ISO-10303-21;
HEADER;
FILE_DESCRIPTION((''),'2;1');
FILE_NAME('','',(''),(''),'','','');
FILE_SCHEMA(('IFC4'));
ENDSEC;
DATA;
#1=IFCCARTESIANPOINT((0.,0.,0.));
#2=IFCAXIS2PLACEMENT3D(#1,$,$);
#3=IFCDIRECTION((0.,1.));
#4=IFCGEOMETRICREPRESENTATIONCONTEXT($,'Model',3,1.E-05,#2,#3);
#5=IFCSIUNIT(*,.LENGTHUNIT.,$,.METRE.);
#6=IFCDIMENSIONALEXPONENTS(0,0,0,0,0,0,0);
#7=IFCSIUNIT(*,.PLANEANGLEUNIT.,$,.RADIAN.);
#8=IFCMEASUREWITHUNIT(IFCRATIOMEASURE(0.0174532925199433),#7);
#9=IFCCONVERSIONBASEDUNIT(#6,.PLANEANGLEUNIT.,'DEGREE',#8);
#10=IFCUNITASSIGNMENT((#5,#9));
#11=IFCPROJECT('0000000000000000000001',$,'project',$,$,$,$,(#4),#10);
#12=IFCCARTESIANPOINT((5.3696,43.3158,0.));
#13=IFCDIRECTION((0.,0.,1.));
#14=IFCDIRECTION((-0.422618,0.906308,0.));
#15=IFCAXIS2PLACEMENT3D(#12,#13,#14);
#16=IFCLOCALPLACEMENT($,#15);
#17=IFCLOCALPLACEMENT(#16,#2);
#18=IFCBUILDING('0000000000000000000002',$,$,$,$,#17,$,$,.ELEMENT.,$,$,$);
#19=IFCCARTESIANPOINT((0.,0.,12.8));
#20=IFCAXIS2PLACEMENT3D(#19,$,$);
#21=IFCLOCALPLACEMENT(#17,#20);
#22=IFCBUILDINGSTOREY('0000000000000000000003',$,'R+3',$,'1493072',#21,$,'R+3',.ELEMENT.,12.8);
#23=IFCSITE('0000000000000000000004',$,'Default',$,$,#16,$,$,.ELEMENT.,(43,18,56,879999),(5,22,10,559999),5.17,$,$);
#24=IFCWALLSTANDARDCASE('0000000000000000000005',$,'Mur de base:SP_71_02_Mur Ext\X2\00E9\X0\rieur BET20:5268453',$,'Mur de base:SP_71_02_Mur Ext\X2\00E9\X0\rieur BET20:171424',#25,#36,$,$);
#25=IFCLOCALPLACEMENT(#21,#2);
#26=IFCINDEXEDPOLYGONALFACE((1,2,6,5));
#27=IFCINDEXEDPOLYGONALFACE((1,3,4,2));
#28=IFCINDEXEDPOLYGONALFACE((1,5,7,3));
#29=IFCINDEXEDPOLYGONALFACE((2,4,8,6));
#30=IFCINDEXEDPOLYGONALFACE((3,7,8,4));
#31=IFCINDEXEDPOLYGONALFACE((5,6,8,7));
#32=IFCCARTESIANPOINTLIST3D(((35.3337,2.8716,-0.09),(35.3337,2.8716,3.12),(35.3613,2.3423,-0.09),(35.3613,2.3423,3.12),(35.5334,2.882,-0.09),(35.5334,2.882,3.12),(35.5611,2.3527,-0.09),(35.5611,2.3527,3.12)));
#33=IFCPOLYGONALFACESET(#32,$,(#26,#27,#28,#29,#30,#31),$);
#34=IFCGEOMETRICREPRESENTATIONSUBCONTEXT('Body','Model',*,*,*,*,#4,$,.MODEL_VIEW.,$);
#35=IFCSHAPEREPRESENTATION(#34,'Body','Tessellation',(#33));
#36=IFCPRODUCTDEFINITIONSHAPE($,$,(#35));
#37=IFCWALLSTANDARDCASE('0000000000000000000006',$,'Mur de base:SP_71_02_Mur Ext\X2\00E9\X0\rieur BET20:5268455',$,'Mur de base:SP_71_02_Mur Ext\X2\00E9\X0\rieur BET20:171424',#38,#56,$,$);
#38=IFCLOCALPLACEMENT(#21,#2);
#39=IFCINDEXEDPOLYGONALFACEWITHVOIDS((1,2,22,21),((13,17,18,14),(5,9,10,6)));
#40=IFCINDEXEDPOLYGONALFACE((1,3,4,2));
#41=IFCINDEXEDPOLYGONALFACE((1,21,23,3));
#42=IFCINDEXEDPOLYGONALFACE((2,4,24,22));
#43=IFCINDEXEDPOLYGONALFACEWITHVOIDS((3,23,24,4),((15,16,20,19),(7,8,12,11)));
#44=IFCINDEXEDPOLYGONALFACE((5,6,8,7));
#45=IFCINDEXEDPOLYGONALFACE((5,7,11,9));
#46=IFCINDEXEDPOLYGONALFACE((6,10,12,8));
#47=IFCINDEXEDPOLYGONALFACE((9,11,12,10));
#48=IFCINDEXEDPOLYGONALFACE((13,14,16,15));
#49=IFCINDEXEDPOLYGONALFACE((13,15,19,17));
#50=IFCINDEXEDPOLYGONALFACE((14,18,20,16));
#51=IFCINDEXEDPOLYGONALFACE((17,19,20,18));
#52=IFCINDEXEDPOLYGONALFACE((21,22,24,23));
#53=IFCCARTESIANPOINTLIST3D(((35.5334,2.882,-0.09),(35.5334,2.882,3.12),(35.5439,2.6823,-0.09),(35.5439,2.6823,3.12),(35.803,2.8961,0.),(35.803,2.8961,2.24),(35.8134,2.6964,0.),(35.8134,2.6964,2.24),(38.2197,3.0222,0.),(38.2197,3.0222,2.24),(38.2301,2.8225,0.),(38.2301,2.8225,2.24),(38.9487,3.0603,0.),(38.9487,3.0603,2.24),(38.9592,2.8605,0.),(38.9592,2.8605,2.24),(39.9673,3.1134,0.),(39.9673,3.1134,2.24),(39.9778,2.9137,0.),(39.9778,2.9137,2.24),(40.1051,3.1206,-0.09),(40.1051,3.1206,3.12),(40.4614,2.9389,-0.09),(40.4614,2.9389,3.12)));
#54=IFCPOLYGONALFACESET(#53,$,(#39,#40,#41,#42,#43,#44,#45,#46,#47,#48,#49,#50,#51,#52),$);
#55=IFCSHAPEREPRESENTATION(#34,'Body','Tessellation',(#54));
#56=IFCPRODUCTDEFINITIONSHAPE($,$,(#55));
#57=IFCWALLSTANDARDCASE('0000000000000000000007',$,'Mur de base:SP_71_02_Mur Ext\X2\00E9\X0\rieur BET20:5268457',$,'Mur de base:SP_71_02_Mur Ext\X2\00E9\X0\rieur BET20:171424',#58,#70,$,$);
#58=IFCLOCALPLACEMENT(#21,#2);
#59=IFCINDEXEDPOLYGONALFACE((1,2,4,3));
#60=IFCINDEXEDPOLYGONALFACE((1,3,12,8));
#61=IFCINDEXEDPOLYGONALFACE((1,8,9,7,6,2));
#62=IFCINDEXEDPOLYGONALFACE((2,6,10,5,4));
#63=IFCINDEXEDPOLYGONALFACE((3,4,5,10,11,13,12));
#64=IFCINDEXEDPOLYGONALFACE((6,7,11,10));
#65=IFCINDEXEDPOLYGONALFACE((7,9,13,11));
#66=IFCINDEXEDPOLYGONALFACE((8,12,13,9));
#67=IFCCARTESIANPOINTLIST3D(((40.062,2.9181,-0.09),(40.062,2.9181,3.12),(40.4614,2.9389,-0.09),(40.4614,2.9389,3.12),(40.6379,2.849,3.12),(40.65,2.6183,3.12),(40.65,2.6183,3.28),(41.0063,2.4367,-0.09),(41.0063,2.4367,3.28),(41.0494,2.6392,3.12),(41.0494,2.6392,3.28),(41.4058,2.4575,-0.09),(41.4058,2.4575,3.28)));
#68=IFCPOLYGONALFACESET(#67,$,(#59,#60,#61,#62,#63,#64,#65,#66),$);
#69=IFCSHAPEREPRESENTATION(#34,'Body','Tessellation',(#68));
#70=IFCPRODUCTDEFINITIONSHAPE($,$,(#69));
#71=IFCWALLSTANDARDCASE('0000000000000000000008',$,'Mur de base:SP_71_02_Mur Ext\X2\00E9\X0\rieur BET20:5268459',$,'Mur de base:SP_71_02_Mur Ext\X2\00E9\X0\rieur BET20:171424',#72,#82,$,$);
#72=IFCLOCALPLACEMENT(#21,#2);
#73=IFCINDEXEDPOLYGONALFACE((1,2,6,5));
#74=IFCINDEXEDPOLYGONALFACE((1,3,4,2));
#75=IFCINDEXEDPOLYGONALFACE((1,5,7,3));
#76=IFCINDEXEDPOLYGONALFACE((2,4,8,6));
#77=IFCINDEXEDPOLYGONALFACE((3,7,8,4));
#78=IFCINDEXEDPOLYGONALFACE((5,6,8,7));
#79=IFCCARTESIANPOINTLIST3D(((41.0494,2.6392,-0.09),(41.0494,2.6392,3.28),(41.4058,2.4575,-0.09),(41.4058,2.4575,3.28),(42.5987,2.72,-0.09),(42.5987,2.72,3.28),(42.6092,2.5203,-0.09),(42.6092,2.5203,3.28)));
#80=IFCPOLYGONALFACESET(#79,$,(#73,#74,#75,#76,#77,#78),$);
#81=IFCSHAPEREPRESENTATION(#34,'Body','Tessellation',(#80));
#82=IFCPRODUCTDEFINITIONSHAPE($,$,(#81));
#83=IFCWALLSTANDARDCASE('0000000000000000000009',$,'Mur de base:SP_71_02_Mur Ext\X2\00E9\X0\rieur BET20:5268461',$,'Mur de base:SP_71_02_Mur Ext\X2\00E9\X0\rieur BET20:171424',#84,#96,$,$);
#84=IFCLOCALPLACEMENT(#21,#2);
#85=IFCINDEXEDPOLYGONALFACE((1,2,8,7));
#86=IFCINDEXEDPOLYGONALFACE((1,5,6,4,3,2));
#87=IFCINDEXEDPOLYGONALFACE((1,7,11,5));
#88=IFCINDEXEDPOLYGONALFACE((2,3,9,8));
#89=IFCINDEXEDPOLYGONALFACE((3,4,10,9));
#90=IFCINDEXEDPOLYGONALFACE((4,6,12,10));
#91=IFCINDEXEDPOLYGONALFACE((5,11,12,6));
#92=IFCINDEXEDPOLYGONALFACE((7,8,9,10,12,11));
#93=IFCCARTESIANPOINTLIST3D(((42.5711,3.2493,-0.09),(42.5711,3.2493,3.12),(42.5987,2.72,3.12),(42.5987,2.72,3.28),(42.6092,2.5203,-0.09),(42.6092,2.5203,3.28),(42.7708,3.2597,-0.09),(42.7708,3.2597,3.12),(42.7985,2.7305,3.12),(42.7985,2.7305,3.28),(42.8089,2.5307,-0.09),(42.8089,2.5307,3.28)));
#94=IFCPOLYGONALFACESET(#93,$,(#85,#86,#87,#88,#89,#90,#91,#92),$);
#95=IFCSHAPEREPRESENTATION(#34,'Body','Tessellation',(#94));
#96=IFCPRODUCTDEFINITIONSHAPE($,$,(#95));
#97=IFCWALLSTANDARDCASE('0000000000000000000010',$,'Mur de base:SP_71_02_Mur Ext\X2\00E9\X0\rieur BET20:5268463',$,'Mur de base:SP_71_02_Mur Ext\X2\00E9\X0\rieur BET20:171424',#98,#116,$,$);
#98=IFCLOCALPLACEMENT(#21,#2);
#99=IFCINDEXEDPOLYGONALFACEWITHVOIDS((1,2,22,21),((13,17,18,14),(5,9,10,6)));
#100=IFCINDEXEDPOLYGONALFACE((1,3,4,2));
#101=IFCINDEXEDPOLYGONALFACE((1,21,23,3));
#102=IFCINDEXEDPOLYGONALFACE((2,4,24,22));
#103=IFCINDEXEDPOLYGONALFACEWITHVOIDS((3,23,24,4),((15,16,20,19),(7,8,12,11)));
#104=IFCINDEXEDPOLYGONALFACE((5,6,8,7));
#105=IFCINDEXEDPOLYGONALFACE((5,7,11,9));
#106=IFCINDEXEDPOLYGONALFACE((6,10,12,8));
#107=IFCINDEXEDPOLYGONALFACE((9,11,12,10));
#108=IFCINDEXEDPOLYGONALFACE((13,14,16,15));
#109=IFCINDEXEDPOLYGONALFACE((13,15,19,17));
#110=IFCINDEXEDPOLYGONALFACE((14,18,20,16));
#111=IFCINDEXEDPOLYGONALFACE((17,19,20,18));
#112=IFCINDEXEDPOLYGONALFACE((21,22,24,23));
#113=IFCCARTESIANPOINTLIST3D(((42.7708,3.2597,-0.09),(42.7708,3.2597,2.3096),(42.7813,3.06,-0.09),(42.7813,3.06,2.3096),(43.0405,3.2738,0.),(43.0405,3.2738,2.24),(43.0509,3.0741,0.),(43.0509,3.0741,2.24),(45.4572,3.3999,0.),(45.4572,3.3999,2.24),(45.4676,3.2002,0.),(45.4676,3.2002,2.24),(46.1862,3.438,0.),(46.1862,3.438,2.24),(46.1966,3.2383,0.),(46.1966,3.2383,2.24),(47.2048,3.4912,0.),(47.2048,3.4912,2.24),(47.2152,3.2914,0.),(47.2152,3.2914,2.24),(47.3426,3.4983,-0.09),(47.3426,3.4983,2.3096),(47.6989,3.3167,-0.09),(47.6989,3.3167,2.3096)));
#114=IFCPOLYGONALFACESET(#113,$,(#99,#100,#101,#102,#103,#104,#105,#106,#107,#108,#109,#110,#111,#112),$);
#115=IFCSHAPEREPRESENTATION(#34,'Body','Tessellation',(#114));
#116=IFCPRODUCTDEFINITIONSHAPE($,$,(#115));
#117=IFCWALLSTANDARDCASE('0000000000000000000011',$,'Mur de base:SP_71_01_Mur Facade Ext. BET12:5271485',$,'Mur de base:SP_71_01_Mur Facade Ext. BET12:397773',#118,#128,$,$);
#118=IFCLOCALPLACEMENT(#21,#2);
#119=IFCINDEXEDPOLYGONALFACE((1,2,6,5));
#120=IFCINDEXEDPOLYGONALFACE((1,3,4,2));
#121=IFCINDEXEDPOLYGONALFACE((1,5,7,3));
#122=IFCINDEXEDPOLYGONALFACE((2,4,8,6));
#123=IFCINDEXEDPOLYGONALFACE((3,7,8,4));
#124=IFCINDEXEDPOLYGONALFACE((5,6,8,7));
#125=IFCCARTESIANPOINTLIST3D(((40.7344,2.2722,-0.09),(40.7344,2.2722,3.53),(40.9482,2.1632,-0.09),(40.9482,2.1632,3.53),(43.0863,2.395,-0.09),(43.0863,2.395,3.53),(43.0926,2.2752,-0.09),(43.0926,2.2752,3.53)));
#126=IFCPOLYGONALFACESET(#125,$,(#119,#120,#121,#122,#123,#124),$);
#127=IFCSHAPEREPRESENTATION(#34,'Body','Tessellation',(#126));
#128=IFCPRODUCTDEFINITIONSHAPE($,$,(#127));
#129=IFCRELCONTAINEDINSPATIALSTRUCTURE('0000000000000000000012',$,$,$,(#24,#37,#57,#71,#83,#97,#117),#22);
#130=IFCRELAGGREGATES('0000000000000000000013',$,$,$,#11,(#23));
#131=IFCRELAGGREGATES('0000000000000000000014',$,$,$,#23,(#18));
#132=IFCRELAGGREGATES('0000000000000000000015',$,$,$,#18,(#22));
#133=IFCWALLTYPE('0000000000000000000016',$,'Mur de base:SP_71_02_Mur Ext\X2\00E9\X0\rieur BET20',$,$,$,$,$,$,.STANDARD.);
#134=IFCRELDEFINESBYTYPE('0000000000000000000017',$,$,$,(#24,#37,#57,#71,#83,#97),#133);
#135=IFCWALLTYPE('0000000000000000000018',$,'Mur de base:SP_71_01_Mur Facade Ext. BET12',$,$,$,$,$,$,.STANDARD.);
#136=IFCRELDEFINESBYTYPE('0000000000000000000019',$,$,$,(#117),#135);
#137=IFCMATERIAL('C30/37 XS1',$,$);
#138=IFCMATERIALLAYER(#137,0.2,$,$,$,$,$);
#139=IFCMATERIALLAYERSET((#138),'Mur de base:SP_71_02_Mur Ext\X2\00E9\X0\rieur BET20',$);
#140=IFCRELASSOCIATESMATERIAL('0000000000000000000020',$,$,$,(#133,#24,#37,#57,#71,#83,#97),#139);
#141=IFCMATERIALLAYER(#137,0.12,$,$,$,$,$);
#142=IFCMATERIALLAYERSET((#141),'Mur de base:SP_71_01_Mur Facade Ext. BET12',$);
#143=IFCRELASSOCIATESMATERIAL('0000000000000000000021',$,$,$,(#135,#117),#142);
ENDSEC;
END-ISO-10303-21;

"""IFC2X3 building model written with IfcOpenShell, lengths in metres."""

from ifc_helpers import new_model, entity, si_unit, converted_unit, direction, frame, frame_2d, origin, place, context, subcontext, project, spatial, polyline, rectangle, outline, extrude, clip, halfspace, bounded_halfspace, material, layer, layer_set, layer_usage, type_object, element, save


model = new_model("IFC2X3")

# Units and contexts
model_context = context("Model", 3, precision=1e-05, world=origin(), true_north=direction((0.0, 1.0)))
body_context = subcontext(model_context, "Body", "Model", "MODEL_VIEW")
ifc_project = project(units=[si_unit("LENGTHUNIT", "METRE"), converted_unit("PLANEANGLEUNIT", "DEGREE", entity("IfcRatioMeasure", 0.0174532925199433), si_unit("PLANEANGLEUNIT", "RADIAN"), dimensions=[0, 0, 0, 0, 0, 0, 0])], contexts=[model_context])

# Site, building, storey
site_placement = place(None, frame((5.3696, 43.3158, 0.0), z_axis=(0.0, 0.0, 1.0), x_axis=(-0.422618, 0.906308, 0.0)))
site = spatial("IfcSite", under=ifc_project, at=site_placement, Name="Default", CompositionType="ELEMENT", RefLatitude=(43, 18, 56, 879999), RefLongitude=(5, 22, 10, 559999), RefElevation=5.17)
building_placement = place(site_placement, origin())
building = spatial("IfcBuilding", under=site, at=building_placement, CompositionType="ELEMENT")
storey_placement = place(building_placement, frame((0.0, 0.0, 12.8)))
storey = spatial("IfcBuildingStorey", under=building, at=storey_placement, Name="R+3", ObjectType="1493072", LongName="R+3", CompositionType="ELEMENT", Elevation=12.8)

# Shared definitions
ifc_material = material(Name="C30/37 XS1")

# Wall
ifc_layer_1 = layer(ifc_material, 0.2)
ifc_layer_set_1 = layer_set([ifc_layer_1], Name="Mur de base:SP_71_02_Mur Extérieur BET20")
ifc_layer_usage_1 = layer_usage(ifc_layer_set_1, "AXIS2", "NEGATIVE", 0.1)
wall_type_1 = type_object("IfcWallType", Name="Mur de base:SP_71_02_Mur Extérieur BET20", PredefinedType="STANDARD", material=ifc_layer_set_1)
wall_1_placement = place(storey_placement, frame((35.4336, 2.8768, -0.09), z_axis=(0.0, 0.0, 1.0), x_axis=(0.05212, -0.998641, 0.0)))
element("IfcWallStandardCase", 1, at=wall_1_placement, inside=storey, type_object=wall_type_1, material=ifc_layer_usage_1, Name="Mur de base:SP_71_02_Mur Extérieur BET20:5268453", ObjectType="Mur de base:SP_71_02_Mur Extérieur BET20:171424", context=body_context, shape_type="Clipping", body=[
    clip(extrude(rectangle(XDim=0.53, YDim=0.2, at=frame_2d((0.265, 0.0), x_axis=(-1.0, 0.0))), origin(), (0.0, 0.0, 1.0), 3.21), bounded_halfspace(frame((0.0, -0.1, 3.21), z_axis=(0.0, 0.0, -1.0), x_axis=(0.998641, -0.05212, 0.0)), True, frame((0.0, -0.1, 3.21), z_axis=(0.0, 0.0, -1.0), x_axis=(0.998641, -0.05212, 0.0)), polyline([(0.0, 0.0), (-0.0104, -0.1997), (0.1893, -0.2102), (0.5189, -0.2274), (0.5293, -0.0276), (0.0, 0.0)]))),
])

# Wall, openings
ifc_layer_usage_2 = layer_usage(ifc_layer_set_1, "AXIS2", "NEGATIVE", 0.1)
wall_2_placement = place(storey_placement, frame((35.5387, 2.7821, -0.09), z_axis=(0.0, 0.0, 1.0), x_axis=(0.998641, 0.05212, 0.0)))
wall_2 = element("IfcWallStandardCase", 2, at=wall_2_placement, inside=storey, type_object=wall_type_1, material=ifc_layer_usage_2, Name="Mur de base:SP_71_02_Mur Extérieur BET20:5268455", ObjectType="Mur de base:SP_71_02_Mur Extérieur BET20:171424", context=body_context, shape_type="Clipping", body=[
    clip(extrude(outline(polyline([(4.9243, -0.1), (4.5778, 0.1), (0.0, 0.1), (0.0, -0.1), (4.5243, -0.1), (4.9243, -0.1)])), origin(), (0.0, 0.0, 1.0), 3.21), bounded_halfspace(frame((0.0, -0.1, 3.21), z_axis=(0.0, 0.0, -1.0), x_axis=(-0.05212, -0.998641, 0.0)), True, frame((0.0, -0.1, 3.21), z_axis=(0.0, 0.0, -1.0), x_axis=(-0.05212, -0.998641, 0.0)), polyline([(0.0, 0.0), (-0.1997, 0.0104), (-0.4383, -4.5612), (-0.2567, -4.9176), (-0.2358, -4.5181), (0.0, 0.0)]))),
])
opening_1_placement = place(wall_2_placement, origin())
element("IfcOpeningElement", 3, at=opening_1_placement, cuts=wall_2, ObjectType="Opening", context=body_context, shape_type="SweptSolid", body=[
    extrude(rectangle(XDim=2.24, YDim=2.42, at=frame_2d((0.0, 0.0), x_axis=(1.0, 0.0))), frame((1.4799, -1.424, 1.21), z_axis=(0.0, 1.0, 0.0), x_axis=(0.0, 0.0, -1.0)), (0.0, 0.0, 1.0), 3.048),
])
opening_2_placement = place(wall_2_placement, origin())
element("IfcOpeningElement", 4, at=opening_2_placement, cuts=wall_2, ObjectType="Opening", context=body_context, shape_type="SweptSolid", body=[
    extrude(rectangle(XDim=2.24, YDim=1.02, at=frame_2d((0.0, 0.0), x_axis=(1.0, 0.0))), frame((3.9299, -1.424, 1.21), z_axis=(0.0, 1.0, 0.0), x_axis=(0.0, 0.0, -1.0)), (0.0, 0.0, 1.0), 3.048),
])

# Walls
ifc_layer_usage_3 = layer_usage(ifc_layer_set_1, "AXIS2", "NEGATIVE", 0.1)
wall_3_placement = place(storey_placement, frame((40.1074, 3.0072, -0.09), z_axis=(0.0, 0.0, 1.0), x_axis=(0.890908, -0.454183, 0.0)))
element("IfcWallStandardCase", 5, at=wall_3_placement, inside=storey, type_object=wall_type_1, material=ifc_layer_usage_3, Name="Mur de base:SP_71_02_Mur Extérieur BET20:5268457", ObjectType="Mur de base:SP_71_02_Mur Extérieur BET20:171424", context=body_context, shape_type="Clipping", body=[
    clip(clip(extrude(outline(polyline([(1.06, -0.1), (1.4064, 0.1), (1.0064, 0.1), (0.3464, 0.1), (0.0, -0.1), (1.06, -0.1)])), origin(), (0.0, 0.0, 1.0), 3.37), bounded_halfspace(frame((0.66, -0.1, 3.21), z_axis=(0.0, 0.0, -1.0), x_axis=(0.454183, -0.890908, 0.0)), True, frame((0.66, -0.1, 3.21), z_axis=(0.0, 0.0, -1.0), x_axis=(0.454183, -0.890908, 0.0)), polyline([(0.0, 0.0), (-0.2998, 0.588), (-0.3206, 0.1885), (-0.0208, -0.3995), (0.0, 0.0)]))), bounded_halfspace(frame((1.0064, 0.1, 3.21), z_axis=(0.5, -0.866025, 0.0), x_axis=(0.0, 0.0, 1.0)), True, frame((1.0064, 0.1, 3.21), z_axis=(0.5, -0.866025, 0.0), x_axis=(0.0, 0.0, 1.0)), polyline([(0.0, 0.0), (0.16, 0.0), (0.16, 0.4), (0.0, 0.4), (0.0, 0.0)]))),
])
ifc_layer_usage_4 = layer_usage(ifc_layer_set_1, "AXIS2", "NEGATIVE", 0.1)
wall_4_placement = place(storey_placement, frame((41.0546, 2.5393, -0.09), z_axis=(0.0, 0.0, 1.0), x_axis=(0.998641, 0.05212, 0.0)))
element("IfcWallStandardCase", 6, at=wall_4_placement, inside=storey, type_object=wall_type_1, material=ifc_layer_usage_4, Name="Mur de base:SP_71_02_Mur Extérieur BET20:5268459", ObjectType="Mur de base:SP_71_02_Mur Extérieur BET20:171424", context=body_context, shape_type="SweptSolid", body=[
    extrude(outline(polyline([(1.5514, -0.1), (1.5514, 0.1), (0.0, 0.1), (0.3464, -0.1), (1.5514, -0.1)])), origin(), (0.0, 0.0, 1.0), 3.37),
])
ifc_layer_usage_5 = layer_usage(ifc_layer_set_1, "AXIS2", "NEGATIVE", 0.1)
wall_5_placement = place(storey_placement, frame((42.671, 3.2545, -0.09), z_axis=(0.0, 0.0, 1.0), x_axis=(0.05212, -0.998641, 0.0)))
element("IfcWallStandardCase", 7, at=wall_5_placement, inside=storey, type_object=wall_type_1, material=ifc_layer_usage_5, Name="Mur de base:SP_71_02_Mur Extérieur BET20:5268461", ObjectType="Mur de base:SP_71_02_Mur Extérieur BET20:171424", context=body_context, shape_type="Clipping", body=[
    clip(clip(extrude(rectangle(XDim=0.73, YDim=0.2, at=frame_2d((0.365, 0.0), x_axis=(-1.0, 0.0))), origin(), (0.0, 0.0, 1.0), 3.37), bounded_halfspace(frame((0.53, -0.1, 3.21), z_axis=(0.0, 0.0, -1.0), x_axis=(0.998641, -0.05212, 0.0)), True, frame((0.53, -0.1, 3.21), z_axis=(0.0, 0.0, -1.0), x_axis=(0.998641, -0.05212, 0.0)), polyline([(0.0, 0.0), (-0.5293, 0.0276), (-0.5397, -0.1721), (-0.0104, -0.1997), (0.0, 0.0)]))), bounded_halfspace(frame((0.53, 0.1, 3.21), z_axis=(1.0, 0.0, 0.0), x_axis=(0.0, 0.0, 1.0)), True, frame((0.53, 0.1, 3.21), z_axis=(1.0, 0.0, 0.0), x_axis=(0.0, 0.0, 1.0)), polyline([(0.0, 0.0), (0.16, 0.0), (0.16, 0.2), (0.0, 0.2), (0.0, 0.0)]))),
])

# Wall, openings
ifc_layer_usage_6 = layer_usage(ifc_layer_set_1, "AXIS2", "NEGATIVE", 0.1)
wall_6_placement = place(storey_placement, frame((42.7761, 3.1599, -0.09), z_axis=(0.0, 0.0, 1.0), x_axis=(0.998641, 0.05212, 0.0)))
wall_6 = element("IfcWallStandardCase", 8, at=wall_6_placement, inside=storey, type_object=wall_type_1, material=ifc_layer_usage_6, Name="Mur de base:SP_71_02_Mur Extérieur BET20:5268463", ObjectType="Mur de base:SP_71_02_Mur Extérieur BET20:171424", context=body_context, shape_type="Clipping", body=[
    clip(extrude(outline(polyline([(4.9244, -0.1), (4.5779, 0.1), (0.0, 0.1), (0.0, -0.1), (4.5244, -0.1), (4.9244, -0.1)])), origin(), (0.0, 0.0, 1.0), 2.3996), bounded_halfspace(frame((0.0, -0.1, 2.3996)), False, frame((0.0, -0.1, 2.3996)), polyline([(0.0, 0.0), (4.5244, 0.0), (4.9244, 0.0), (4.5779, 0.2), (0.0, 0.2), (0.0, 0.0)]))),
])
opening_3_placement = place(wall_6_placement, origin())
element("IfcOpeningElement", 9, at=opening_3_placement, cuts=wall_6, ObjectType="Opening", context=body_context, shape_type="SweptSolid", body=[
    extrude(rectangle(XDim=2.24, YDim=1.02, at=frame_2d((0.0, 0.0), x_axis=(1.0, 0.0))), frame((3.93, -1.424, 1.21), z_axis=(0.0, 1.0, 0.0), x_axis=(0.0, 0.0, -1.0)), (0.0, 0.0, 1.0), 3.048),
])
opening_4_placement = place(wall_6_placement, origin())
element("IfcOpeningElement", 10, at=opening_4_placement, cuts=wall_6, ObjectType="Opening", context=body_context, shape_type="SweptSolid", body=[
    extrude(rectangle(XDim=2.24, YDim=2.42, at=frame_2d((0.0, 0.0), x_axis=(1.0, 0.0))), frame((1.48, -1.424, 1.21), z_axis=(0.0, 1.0, 0.0), x_axis=(0.0, 0.0, -1.0)), (0.0, 0.0, 1.0), 3.048),
])

# Shared definitions
ifc_layer_2 = layer(ifc_material, 0.12)
ifc_layer_set_2 = layer_set([ifc_layer_2], Name="Mur de base:SP_71_01_Mur Facade Ext. BET12")
wall_type_2 = type_object("IfcWallType", Name="Mur de base:SP_71_01_Mur Facade Ext. BET12", PredefinedType="STANDARD", material=ifc_layer_set_2)

# Wall
ifc_layer_usage_7 = layer_usage(ifc_layer_set_2, "AXIS2", "NEGATIVE", 0.06)
wall_7_placement = place(storey_placement, frame((43.0895, 2.3351, -0.09), z_axis=(0.0, 0.0, 1.0), x_axis=(-0.998641, -0.05212, 0.0)))
element("IfcWallStandardCase", 11, at=wall_7_placement, inside=storey, type_object=wall_type_2, material=ifc_layer_usage_7, Name="Mur de base:SP_71_01_Mur Facade Ext. BET12:5271485", ObjectType="Mur de base:SP_71_01_Mur Facade Ext. BET12:397773", context=body_context, shape_type="Clipping", body=[
    clip(extrude(outline(polyline([(2.3552, -0.06), (2.1473, 0.06), (0.0, 0.06), (0.0, -0.06), (0.12, -0.06), (2.1152, -0.06), (2.3552, -0.06)])), origin(), (0.0, 0.0, 1.0), 3.62), halfspace(frame((0.0, 0.0, -0.09)), True)),
])

save(model, "model.ifc")
